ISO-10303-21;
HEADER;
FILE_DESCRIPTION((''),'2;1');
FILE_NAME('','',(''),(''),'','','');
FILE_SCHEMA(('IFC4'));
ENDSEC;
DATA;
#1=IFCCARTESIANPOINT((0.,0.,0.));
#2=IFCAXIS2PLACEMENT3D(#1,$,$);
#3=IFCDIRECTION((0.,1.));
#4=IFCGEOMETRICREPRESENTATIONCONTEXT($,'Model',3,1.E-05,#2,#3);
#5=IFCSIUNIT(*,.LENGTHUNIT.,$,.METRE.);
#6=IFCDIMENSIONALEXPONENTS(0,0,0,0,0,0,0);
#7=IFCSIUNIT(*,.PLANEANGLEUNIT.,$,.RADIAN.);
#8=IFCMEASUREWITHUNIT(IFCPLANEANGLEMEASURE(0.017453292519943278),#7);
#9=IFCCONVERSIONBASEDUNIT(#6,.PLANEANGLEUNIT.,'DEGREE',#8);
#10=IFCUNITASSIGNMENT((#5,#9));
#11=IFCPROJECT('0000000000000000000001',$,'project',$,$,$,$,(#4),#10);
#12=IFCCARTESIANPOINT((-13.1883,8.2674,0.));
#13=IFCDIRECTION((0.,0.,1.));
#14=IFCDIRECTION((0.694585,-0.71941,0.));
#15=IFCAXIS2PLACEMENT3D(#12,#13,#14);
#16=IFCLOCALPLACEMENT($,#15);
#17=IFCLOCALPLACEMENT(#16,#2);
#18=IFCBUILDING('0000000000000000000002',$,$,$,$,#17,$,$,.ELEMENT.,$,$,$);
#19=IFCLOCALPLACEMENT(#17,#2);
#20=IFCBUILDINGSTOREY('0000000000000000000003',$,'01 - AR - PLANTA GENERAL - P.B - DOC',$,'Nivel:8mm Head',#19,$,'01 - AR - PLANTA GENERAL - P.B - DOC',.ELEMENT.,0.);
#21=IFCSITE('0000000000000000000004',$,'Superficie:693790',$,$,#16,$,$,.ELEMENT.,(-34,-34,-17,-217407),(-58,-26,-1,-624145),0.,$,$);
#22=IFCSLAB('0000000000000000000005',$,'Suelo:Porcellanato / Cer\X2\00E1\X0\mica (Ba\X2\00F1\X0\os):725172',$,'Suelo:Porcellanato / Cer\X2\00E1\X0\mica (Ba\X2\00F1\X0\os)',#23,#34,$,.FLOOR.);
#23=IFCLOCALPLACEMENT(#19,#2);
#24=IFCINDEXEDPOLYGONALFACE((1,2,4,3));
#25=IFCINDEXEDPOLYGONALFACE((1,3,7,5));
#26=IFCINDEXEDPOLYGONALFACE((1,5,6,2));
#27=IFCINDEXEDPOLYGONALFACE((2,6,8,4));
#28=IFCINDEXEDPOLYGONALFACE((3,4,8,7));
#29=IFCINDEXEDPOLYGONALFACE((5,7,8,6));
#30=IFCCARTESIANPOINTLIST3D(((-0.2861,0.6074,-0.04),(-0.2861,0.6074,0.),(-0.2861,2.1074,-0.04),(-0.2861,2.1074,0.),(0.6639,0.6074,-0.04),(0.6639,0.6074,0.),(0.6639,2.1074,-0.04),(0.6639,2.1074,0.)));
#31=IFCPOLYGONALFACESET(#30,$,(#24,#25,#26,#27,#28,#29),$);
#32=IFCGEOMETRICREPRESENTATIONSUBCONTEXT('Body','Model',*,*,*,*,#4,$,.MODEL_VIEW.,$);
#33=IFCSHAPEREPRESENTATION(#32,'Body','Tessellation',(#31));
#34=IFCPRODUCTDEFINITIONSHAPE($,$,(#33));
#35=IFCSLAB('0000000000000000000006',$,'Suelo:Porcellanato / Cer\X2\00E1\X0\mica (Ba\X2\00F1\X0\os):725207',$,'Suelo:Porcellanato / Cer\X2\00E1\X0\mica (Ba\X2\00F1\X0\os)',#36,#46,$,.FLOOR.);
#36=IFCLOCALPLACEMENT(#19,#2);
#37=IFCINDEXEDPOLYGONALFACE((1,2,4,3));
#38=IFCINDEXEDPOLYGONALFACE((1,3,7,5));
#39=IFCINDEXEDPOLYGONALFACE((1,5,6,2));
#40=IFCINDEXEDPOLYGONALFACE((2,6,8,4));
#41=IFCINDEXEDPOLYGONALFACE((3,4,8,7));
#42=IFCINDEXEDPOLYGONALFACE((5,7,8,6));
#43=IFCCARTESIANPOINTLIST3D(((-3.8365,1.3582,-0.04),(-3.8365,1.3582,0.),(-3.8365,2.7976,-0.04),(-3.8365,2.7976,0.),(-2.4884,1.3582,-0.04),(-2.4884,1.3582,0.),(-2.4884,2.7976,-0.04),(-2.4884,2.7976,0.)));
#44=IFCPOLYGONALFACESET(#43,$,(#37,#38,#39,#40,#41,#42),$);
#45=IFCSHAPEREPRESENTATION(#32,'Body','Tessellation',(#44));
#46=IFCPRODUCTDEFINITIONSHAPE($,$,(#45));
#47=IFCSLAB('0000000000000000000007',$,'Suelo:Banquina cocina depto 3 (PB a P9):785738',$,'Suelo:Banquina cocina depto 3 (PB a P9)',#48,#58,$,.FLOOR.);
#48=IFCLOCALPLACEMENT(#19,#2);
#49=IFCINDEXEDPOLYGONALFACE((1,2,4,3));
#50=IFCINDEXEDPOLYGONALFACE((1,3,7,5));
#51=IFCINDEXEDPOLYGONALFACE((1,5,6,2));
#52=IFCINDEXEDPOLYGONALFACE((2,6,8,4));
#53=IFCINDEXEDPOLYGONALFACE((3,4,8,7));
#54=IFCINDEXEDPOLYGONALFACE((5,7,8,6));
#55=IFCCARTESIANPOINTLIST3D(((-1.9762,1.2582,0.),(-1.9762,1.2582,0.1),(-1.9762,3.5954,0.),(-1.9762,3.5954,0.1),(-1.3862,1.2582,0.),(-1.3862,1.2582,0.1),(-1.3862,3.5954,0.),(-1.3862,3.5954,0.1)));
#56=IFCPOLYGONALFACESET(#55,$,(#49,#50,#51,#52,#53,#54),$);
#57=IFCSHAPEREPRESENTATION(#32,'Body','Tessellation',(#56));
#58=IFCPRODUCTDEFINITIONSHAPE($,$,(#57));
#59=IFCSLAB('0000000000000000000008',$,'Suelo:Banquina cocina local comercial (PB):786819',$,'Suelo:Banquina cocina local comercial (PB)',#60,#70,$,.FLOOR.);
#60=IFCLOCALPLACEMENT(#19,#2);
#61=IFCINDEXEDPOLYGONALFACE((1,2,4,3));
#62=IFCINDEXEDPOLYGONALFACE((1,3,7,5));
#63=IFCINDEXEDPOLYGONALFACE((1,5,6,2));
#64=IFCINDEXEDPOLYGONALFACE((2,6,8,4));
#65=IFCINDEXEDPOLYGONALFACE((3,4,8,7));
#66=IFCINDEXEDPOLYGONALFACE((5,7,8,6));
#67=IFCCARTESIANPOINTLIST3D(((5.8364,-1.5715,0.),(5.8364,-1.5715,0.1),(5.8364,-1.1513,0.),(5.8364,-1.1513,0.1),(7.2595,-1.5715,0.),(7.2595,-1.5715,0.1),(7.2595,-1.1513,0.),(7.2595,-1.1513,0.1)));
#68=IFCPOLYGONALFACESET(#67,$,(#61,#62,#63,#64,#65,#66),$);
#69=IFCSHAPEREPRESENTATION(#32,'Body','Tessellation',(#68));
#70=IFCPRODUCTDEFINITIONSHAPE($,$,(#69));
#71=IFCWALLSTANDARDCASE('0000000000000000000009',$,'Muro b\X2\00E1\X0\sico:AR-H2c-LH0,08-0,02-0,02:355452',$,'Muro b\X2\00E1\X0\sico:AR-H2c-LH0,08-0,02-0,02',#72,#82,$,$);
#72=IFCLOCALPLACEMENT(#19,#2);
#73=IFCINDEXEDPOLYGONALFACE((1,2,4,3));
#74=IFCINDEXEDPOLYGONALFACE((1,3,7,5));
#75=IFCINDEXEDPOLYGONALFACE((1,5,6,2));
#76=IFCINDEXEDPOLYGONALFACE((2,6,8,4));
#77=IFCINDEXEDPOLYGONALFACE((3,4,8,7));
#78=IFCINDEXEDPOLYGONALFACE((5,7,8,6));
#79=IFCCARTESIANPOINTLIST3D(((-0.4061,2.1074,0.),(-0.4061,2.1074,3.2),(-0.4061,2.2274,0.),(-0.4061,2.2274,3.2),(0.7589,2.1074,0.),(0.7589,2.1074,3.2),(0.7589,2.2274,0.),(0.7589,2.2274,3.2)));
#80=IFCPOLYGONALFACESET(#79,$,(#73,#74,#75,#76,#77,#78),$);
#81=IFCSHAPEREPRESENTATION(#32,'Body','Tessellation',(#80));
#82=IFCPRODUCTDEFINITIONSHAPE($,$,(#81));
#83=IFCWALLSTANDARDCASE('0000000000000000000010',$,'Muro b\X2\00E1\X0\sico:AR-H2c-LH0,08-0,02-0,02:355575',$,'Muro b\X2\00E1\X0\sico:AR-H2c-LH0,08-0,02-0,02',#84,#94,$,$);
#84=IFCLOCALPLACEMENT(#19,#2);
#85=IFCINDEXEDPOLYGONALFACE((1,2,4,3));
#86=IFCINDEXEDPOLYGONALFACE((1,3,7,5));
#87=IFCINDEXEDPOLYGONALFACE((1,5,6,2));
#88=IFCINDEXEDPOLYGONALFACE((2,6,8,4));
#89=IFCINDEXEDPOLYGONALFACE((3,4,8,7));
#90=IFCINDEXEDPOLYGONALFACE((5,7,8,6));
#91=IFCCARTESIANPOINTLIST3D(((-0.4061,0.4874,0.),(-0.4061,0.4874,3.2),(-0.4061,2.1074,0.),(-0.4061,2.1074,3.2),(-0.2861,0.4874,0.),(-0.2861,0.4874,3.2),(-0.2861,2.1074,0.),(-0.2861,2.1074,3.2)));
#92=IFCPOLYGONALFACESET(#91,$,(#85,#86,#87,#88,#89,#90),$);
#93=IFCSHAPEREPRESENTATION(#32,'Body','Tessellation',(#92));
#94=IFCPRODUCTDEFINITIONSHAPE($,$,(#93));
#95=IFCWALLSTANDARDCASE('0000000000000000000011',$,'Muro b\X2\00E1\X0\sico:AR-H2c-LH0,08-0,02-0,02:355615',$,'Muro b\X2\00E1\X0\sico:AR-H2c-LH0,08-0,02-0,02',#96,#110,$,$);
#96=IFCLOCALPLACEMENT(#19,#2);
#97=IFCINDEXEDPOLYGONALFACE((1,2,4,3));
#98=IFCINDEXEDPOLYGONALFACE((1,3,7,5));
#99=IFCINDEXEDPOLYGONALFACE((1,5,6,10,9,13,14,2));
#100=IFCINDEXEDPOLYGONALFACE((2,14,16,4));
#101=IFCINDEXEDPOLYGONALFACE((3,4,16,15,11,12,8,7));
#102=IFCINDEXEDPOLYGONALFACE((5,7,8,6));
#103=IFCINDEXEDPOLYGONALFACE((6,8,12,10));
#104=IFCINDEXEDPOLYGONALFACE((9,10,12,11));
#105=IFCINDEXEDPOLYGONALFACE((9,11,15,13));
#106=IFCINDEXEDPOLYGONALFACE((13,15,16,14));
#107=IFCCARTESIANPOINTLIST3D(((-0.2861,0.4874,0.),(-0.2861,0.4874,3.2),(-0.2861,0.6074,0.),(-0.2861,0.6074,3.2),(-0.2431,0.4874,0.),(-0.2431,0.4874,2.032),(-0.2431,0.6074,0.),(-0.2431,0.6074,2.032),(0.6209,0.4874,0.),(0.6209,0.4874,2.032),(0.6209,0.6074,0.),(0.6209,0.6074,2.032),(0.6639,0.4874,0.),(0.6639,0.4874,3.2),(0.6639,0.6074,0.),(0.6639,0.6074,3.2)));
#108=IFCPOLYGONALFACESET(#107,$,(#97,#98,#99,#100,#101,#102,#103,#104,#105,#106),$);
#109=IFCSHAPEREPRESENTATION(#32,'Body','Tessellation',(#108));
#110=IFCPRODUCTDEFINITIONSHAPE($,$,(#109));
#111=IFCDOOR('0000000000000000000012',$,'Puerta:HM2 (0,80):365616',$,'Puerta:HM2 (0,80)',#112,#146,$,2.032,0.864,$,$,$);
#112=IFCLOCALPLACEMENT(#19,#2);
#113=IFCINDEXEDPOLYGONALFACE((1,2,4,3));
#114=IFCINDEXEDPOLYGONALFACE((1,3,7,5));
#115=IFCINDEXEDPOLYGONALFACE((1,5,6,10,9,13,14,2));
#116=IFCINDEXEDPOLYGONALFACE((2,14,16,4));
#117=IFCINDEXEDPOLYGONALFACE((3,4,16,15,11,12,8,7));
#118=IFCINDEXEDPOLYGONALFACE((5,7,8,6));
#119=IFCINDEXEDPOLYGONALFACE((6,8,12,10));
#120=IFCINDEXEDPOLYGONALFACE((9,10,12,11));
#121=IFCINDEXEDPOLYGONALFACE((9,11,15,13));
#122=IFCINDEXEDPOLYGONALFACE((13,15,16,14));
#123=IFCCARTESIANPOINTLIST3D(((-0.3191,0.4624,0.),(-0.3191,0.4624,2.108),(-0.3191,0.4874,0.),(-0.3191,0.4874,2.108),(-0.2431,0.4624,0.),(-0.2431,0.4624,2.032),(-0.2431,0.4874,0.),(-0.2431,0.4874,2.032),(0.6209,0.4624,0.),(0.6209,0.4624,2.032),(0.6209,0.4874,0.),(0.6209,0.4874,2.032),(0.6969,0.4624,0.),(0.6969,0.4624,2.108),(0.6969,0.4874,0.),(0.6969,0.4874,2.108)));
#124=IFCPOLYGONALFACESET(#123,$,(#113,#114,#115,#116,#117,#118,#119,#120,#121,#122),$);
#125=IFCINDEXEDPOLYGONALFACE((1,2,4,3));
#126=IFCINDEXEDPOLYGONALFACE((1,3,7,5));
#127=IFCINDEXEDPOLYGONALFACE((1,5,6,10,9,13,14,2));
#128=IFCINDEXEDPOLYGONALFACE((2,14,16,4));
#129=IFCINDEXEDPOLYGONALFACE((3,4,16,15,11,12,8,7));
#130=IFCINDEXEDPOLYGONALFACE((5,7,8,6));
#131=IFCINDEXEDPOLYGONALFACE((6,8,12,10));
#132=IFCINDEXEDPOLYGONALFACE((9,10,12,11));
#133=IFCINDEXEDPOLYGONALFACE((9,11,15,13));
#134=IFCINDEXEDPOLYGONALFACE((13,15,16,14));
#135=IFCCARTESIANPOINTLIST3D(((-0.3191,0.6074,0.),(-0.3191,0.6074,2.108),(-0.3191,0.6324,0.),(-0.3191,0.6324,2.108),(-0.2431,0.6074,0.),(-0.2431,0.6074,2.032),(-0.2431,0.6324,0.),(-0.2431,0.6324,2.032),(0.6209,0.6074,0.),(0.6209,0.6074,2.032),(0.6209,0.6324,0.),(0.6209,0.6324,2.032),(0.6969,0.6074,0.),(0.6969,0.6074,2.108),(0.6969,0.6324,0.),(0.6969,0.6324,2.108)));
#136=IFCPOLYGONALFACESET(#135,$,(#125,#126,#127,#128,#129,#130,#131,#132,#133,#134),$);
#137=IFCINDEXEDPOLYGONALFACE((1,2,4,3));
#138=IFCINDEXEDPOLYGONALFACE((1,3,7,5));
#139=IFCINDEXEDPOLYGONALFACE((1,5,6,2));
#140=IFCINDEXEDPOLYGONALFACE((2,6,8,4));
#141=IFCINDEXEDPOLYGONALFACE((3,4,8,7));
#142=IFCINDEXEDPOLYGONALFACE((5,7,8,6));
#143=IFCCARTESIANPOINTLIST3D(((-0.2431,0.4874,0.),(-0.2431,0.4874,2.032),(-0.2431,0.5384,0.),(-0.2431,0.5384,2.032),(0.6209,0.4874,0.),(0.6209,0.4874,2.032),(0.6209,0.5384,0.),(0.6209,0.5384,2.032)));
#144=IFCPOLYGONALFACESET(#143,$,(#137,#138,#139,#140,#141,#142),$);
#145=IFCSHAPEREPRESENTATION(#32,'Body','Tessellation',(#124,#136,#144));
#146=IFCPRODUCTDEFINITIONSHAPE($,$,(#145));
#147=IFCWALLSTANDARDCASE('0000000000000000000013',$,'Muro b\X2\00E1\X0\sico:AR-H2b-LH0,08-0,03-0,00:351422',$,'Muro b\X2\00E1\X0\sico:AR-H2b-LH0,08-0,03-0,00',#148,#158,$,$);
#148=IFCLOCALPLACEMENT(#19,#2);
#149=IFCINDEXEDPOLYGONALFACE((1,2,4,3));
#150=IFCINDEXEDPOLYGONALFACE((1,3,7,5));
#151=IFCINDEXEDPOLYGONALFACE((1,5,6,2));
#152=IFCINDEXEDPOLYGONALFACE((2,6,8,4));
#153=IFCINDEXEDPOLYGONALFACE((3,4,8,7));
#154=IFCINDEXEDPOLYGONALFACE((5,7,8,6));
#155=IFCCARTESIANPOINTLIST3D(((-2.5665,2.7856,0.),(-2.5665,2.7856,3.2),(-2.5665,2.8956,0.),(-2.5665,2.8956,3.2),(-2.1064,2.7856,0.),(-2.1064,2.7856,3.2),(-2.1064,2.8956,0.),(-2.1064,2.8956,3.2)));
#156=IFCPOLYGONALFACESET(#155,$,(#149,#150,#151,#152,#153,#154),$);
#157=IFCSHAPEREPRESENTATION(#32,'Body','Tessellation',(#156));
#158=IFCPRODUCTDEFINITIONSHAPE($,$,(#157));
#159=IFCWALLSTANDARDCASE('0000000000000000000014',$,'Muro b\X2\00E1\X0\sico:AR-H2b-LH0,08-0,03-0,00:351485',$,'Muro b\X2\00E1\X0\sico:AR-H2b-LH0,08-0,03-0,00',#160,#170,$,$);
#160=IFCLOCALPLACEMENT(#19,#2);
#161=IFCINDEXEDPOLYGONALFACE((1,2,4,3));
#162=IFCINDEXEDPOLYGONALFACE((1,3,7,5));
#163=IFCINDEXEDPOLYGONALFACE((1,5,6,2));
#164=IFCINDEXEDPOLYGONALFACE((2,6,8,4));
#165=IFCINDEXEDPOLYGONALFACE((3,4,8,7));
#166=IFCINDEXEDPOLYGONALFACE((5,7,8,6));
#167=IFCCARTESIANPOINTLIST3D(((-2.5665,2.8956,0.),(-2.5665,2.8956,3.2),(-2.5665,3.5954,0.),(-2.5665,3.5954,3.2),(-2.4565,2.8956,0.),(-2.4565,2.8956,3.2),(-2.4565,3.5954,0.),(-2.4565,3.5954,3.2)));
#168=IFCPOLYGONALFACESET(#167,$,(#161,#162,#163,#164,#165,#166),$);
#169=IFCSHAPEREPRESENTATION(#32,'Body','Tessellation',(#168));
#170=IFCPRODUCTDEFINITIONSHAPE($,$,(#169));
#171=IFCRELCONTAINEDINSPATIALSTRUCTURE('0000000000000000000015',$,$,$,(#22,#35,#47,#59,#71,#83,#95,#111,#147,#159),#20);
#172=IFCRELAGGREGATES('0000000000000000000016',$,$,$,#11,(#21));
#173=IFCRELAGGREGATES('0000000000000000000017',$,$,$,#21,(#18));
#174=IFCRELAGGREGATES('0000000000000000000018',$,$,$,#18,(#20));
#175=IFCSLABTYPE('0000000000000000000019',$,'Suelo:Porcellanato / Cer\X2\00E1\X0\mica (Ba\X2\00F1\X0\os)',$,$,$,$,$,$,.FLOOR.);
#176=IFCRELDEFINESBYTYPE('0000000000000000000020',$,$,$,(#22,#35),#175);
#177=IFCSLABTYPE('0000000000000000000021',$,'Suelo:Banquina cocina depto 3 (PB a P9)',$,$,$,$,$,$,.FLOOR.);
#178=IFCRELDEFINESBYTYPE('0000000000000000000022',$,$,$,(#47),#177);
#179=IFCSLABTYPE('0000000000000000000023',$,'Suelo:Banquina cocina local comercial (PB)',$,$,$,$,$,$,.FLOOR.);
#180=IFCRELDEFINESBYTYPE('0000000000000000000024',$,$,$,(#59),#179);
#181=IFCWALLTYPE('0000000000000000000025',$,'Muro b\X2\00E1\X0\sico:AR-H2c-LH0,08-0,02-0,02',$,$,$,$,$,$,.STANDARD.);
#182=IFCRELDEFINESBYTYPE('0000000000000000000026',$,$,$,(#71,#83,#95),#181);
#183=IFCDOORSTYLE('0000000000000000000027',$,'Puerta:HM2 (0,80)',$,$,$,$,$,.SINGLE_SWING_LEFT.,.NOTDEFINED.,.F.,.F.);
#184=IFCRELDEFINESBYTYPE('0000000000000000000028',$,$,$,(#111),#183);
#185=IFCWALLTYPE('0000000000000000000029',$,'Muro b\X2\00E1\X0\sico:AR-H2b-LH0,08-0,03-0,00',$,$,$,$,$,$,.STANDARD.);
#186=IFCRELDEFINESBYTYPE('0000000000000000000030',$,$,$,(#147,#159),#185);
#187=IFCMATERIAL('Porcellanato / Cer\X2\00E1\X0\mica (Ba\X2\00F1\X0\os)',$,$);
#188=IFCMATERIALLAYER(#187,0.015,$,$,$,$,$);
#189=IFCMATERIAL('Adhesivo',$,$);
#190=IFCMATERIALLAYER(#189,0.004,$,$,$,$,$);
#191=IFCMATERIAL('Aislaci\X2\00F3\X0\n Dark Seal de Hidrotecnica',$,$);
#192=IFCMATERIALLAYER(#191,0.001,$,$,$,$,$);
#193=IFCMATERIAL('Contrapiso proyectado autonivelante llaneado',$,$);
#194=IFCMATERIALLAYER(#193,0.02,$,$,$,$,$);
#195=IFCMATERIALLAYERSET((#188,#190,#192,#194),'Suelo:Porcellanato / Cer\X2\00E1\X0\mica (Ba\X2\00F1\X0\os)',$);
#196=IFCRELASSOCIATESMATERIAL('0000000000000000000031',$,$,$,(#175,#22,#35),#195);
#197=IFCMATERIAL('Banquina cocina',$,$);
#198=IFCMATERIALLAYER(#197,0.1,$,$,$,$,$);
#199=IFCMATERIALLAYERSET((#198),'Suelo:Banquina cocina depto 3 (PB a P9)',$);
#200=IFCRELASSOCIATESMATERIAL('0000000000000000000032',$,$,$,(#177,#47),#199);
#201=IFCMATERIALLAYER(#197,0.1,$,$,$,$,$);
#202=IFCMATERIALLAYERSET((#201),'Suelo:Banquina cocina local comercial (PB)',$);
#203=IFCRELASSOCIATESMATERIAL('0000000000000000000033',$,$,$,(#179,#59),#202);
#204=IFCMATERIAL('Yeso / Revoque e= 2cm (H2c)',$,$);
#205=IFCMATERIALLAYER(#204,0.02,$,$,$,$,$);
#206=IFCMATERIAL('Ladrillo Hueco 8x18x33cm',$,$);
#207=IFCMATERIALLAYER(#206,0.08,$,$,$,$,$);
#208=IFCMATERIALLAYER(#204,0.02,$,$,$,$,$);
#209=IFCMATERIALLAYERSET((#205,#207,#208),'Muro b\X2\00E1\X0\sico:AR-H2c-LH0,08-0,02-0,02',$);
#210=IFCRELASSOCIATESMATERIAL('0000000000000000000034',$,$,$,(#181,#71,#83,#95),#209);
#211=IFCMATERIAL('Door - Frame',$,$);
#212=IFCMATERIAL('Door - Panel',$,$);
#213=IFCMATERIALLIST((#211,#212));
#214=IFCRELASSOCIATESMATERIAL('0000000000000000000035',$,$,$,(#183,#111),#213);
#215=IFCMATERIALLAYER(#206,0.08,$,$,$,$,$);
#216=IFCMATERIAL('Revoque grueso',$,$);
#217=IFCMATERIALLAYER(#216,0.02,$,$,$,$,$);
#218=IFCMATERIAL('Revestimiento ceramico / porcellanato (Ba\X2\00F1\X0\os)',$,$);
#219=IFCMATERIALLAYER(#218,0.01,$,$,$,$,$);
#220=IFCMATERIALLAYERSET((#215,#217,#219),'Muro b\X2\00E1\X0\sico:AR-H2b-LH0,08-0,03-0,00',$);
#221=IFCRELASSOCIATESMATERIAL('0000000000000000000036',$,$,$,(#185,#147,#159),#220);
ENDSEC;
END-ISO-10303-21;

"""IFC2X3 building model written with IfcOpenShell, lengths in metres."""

from ifc_helpers import new_model, entity, si_unit, converted_unit, direction, frame, frame_2d, origin, origin_2d_with_axis, place, context, subcontext, project, spatial, polyline, rectangle, outline, extrude, source, transform, mapped, material, material_list, layer, layer_set, layer_usage, type_object, type_shapes, element, fill, save


model = new_model("IFC2X3")

# Units and contexts
model_context = context("Model", 3, precision=1e-05, world=origin(), true_north=direction((0.0, 1.0)))
body_context = subcontext(model_context, "Body", "Model", "MODEL_VIEW")
ifc_project = project(units=[si_unit("LENGTHUNIT", "METRE"), converted_unit("PLANEANGLEUNIT", "DEGREE", entity("IfcPlaneAngleMeasure", 0.017453292519943278), si_unit("PLANEANGLEUNIT", "RADIAN"), dimensions=[0, 0, 0, 0, 0, 0, 0])], contexts=[model_context])

# Site, building, storey
site_placement = place(None, frame((-13.1883, 8.2674, 0.0), z_axis=(0.0, 0.0, 1.0), x_axis=(0.694585, -0.71941, 0.0)))
site = spatial("IfcSite", under=ifc_project, at=site_placement, Name="Superficie:693790", CompositionType="ELEMENT", RefLatitude=(-34, -34, -17, -217407), RefLongitude=(-58, -26, -1, -624145), RefElevation=0.0)
building_placement = place(site_placement, origin())
building = spatial("IfcBuilding", under=site, at=building_placement, CompositionType="ELEMENT")
storey_placement = place(building_placement, origin())
storey = spatial("IfcBuildingStorey", under=building, at=storey_placement, Name="01 - AR - PLANTA GENERAL - P.B - DOC", ObjectType="Nivel:8mm Head", LongName="01 - AR - PLANTA GENERAL - P.B - DOC", CompositionType="ELEMENT", Elevation=0.0)

# Slabs
ifc_material_1 = material(Name="Adhesivo")
ifc_material_2 = material(Name="Contrapiso proyectado autonivelante llaneado")
ifc_material_3 = material(Name="Porcellanato / Cerámica (Baños)")
ifc_layer_1 = layer(ifc_material_3, 0.015)
ifc_layer_2 = layer(ifc_material_1, 0.004)
ifc_material_4 = material(Name="Aislación Dark Seal de Hidrotecnica")
ifc_layer_3 = layer(ifc_material_4, 0.001)
ifc_layer_4 = layer(ifc_material_2, 0.02)
ifc_layer_set_1 = layer_set([ifc_layer_1, ifc_layer_2, ifc_layer_3, ifc_layer_4], Name="Suelo:Porcellanato / Cerámica (Baños)")
ifc_layer_usage_1 = layer_usage(ifc_layer_set_1, "AXIS3", "POSITIVE", 0.0)
slab_type_1 = type_object("IfcSlabType", Name="Suelo:Porcellanato / Cerámica (Baños)", PredefinedType="FLOOR", material=ifc_layer_set_1)
slab_1_placement = place(storey_placement, origin())
element("IfcSlab", 1, at=slab_1_placement, inside=storey, type_object=slab_type_1, material=ifc_layer_usage_1, Name="Suelo:Porcellanato / Cerámica (Baños):725172", ObjectType="Suelo:Porcellanato / Cerámica (Baños)", PredefinedType="FLOOR", context=body_context, shape_type="SweptSolid", body=[
    extrude(rectangle(XDim=1.5, YDim=0.95, at=frame_2d((0.0, 0.0), x_axis=(1.0, 0.0))), frame((0.1889, 1.3574, 0.0), z_axis=(0.0, 0.0, -1.0), x_axis=(0.0, 1.0, 0.0)), (0.0, 0.0, 1.0), 0.04),
])
ifc_layer_usage_2 = layer_usage(ifc_layer_set_1, "AXIS3", "POSITIVE", 0.0)
slab_2_placement = place(storey_placement, origin())
element("IfcSlab", 2, at=slab_2_placement, inside=storey, type_object=slab_type_1, material=ifc_layer_usage_2, Name="Suelo:Porcellanato / Cerámica (Baños):725207", ObjectType="Suelo:Porcellanato / Cerámica (Baños)", PredefinedType="FLOOR", context=body_context, shape_type="SweptSolid", body=[
    extrude(rectangle(XDim=1.4395, YDim=1.348, at=frame_2d((0.0, 0.0), x_axis=(1.0, 0.0))), frame((-3.1625, 2.0779, 0.0), z_axis=(0.0, 0.0, -1.0), x_axis=(0.0, 1.0, 0.0)), (0.0, 0.0, 1.0), 0.04),
])
ifc_material_5 = material(Name="Banquina cocina")
ifc_layer_5 = layer(ifc_material_5, 0.1)
ifc_layer_set_2 = layer_set([ifc_layer_5], Name="Suelo:Banquina cocina depto 3 (PB a P9)")
ifc_layer_usage_3 = layer_usage(ifc_layer_set_2, "AXIS3", "POSITIVE", 0.0)
slab_type_2 = type_object("IfcSlabType", Name="Suelo:Banquina cocina depto 3 (PB a P9)", PredefinedType="FLOOR", material=ifc_layer_set_2)
slab_3_placement = place(storey_placement, origin())
element("IfcSlab", 3, at=slab_3_placement, inside=storey, type_object=slab_type_2, material=ifc_layer_usage_3, Name="Suelo:Banquina cocina depto 3 (PB a P9):785738", ObjectType="Suelo:Banquina cocina depto 3 (PB a P9)", PredefinedType="FLOOR", context=body_context, shape_type="SweptSolid", body=[
    extrude(rectangle(XDim=2.3373, YDim=0.59, at=frame_2d((0.0, 0.0), x_axis=(1.0, 0.0))), frame((-1.6812, 2.4268, 0.1), z_axis=(0.0, 0.0, -1.0), x_axis=(0.0, 1.0, 0.0)), (0.0, 0.0, 1.0), 0.1),
])
ifc_layer_6 = layer(ifc_material_5, 0.1)
ifc_layer_set_3 = layer_set([ifc_layer_6], Name="Suelo:Banquina cocina local comercial (PB)")
ifc_layer_usage_4 = layer_usage(ifc_layer_set_3, "AXIS3", "POSITIVE", 0.0)
slab_type_3 = type_object("IfcSlabType", Name="Suelo:Banquina cocina local comercial (PB)", PredefinedType="FLOOR", material=ifc_layer_set_3)
slab_4_placement = place(storey_placement, origin())
element("IfcSlab", 4, at=slab_4_placement, inside=storey, type_object=slab_type_3, material=ifc_layer_usage_4, Name="Suelo:Banquina cocina local comercial (PB):786819", ObjectType="Suelo:Banquina cocina local comercial (PB)", PredefinedType="FLOOR", context=body_context, shape_type="SweptSolid", body=[
    extrude(rectangle(XDim=0.4202, YDim=1.4231, at=frame_2d((0.0, 0.0), x_axis=(1.0, 0.0))), frame((6.548, -1.3614, 0.1), z_axis=(0.0, 0.0, -1.0), x_axis=(0.0, 1.0, 0.0)), (0.0, 0.0, 1.0), 0.1),
])

# Walls
ifc_material_6 = material(Name="Yeso / Revoque e= 2cm (H2c)")
ifc_layer_7 = layer(ifc_material_6, 0.02)
ifc_material_7 = material(Name="Ladrillo Hueco 8x18x33cm")
ifc_layer_8 = layer(ifc_material_7, 0.08)
ifc_layer_9 = layer(ifc_material_6, 0.02)
ifc_layer_set_4 = layer_set([ifc_layer_7, ifc_layer_8, ifc_layer_9], Name="Muro básico:AR-H2c-LH0,08-0,02-0,02")
ifc_layer_usage_5 = layer_usage(ifc_layer_set_4, "AXIS2", "NEGATIVE", 0.06)
wall_type_1 = type_object("IfcWallType", Name="Muro básico:AR-H2c-LH0,08-0,02-0,02", PredefinedType="STANDARD", material=ifc_layer_set_4)
wall_1_placement = place(storey_placement, frame((-0.4061, 2.1674, 0.0)))
element("IfcWallStandardCase", 5, at=wall_1_placement, inside=storey, type_object=wall_type_1, material=ifc_layer_usage_5, Name="Muro básico:AR-H2c-LH0,08-0,02-0,02:355452", ObjectType="Muro básico:AR-H2c-LH0,08-0,02-0,02", context=body_context, shape_type="SweptSolid", body=[
    extrude(rectangle(XDim=1.165, YDim=0.12, at=frame_2d((0.5825, 0.0), x_axis=(-1.0, 0.0))), origin(), (0.0, 0.0, 1.0), 3.2),
])
ifc_layer_usage_6 = layer_usage(ifc_layer_set_4, "AXIS2", "POSITIVE", -0.06)
wall_2_placement = place(storey_placement, frame((-0.3461, 2.1074, 0.0), z_axis=(0.0, 0.0, 1.0), x_axis=(0.0, -1.0, 0.0)))
element("IfcWallStandardCase", 6, at=wall_2_placement, inside=storey, type_object=wall_type_1, material=ifc_layer_usage_6, Name="Muro básico:AR-H2c-LH0,08-0,02-0,02:355575", ObjectType="Muro básico:AR-H2c-LH0,08-0,02-0,02", context=body_context, shape_type="SweptSolid", body=[
    extrude(rectangle(XDim=1.62, YDim=0.12, at=frame_2d((0.81, 0.0), x_axis=(-1.0, 0.0))), origin(), (0.0, 0.0, 1.0), 3.2),
])

# Wall, opening, door
ifc_layer_usage_7 = layer_usage(ifc_layer_set_4, "AXIS2", "POSITIVE", -0.06)
wall_3_placement = place(storey_placement, frame((-0.2861, 0.5474, 0.0)))
wall_3 = element("IfcWallStandardCase", 7, at=wall_3_placement, inside=storey, type_object=wall_type_1, material=ifc_layer_usage_7, Name="Muro básico:AR-H2c-LH0,08-0,02-0,02:355615", ObjectType="Muro básico:AR-H2c-LH0,08-0,02-0,02", context=body_context, shape_type="SweptSolid", body=[
    extrude(rectangle(XDim=0.95, YDim=0.12, at=frame_2d((0.475, 0.0), x_axis=(1.0, 0.0))), origin(), (0.0, 0.0, 1.0), 3.2),
])
opening_placement = place(wall_3_placement, frame((0.907, 0.06, 0.0)))
opening = element("IfcOpeningElement", 8, at=opening_placement, cuts=wall_3, ObjectType="Opening", context=body_context, shape_type="SweptSolid", body=[
    extrude(rectangle(XDim=0.864, YDim=2.032, at=frame_2d((1.016, 0.432), x_axis=(0.0, -1.0))), frame((0.0, 0.0, 0.0), z_axis=(0.0, -1.0, 0.0), x_axis=(0.0, 0.0, 1.0)), (0.0, 0.0, 1.0), 0.12),
])
ifc_material_8 = material(Name="Door - Frame")
ifc_material_9 = material(Name="Door - Panel")
ifc_material_list_1 = material_list([ifc_material_8, ifc_material_9])
door_style = type_object("IfcDoorStyle", Name="Puerta:HM2 (0,80)", ConstructionType="NOTDEFINED", OperationType="SINGLE_SWING_LEFT", ParameterTakesPrecedence=False, Sizeable=False, material=ifc_material_list_1)
shared_shape_1 = source(origin(), body_context, "Body", "SweptSolid", [
    extrude(outline(polyline([(-0.508, -1.073), (0.508, -1.073), (0.508, 1.035), (0.432, 1.035), (0.432, -0.997), (-0.432, -0.997), (-0.432, 1.035), (-0.508, 1.035), (-0.508, -1.073)])), frame((0.432, 0.145, 1.035), z_axis=(0.0, -1.0, 0.0), x_axis=(-1.0, 0.0, 0.0)), (0.0, 0.0, 1.0), 0.025),
    extrude(outline(polyline([(-1.073, -0.508), (1.035, -0.508), (1.035, -0.432), (-0.997, -0.432), (-0.997, 0.432), (1.035, 0.432), (1.035, 0.508), (-1.073, 0.508), (-1.073, -0.508)])), frame((0.432, 0.0, 1.035), z_axis=(0.0, -1.0, 0.0), x_axis=(0.0, 0.0, -1.0)), (0.0, 0.0, 1.0), 0.025),
    extrude(rectangle(XDim=0.864, YDim=0.051, at=origin_2d_with_axis()), frame((0.432, 0.0945, 0.0)), (0.0, 0.0, 1.0), 2.032),
])
type_shapes(door_style, [shared_shape_1])
door_placement = place(opening_placement, frame((0.0, 0.0, 0.0), z_axis=(0.0, 0.0, 1.0), x_axis=(-1.0, 0.0, 0.0)))
door = element("IfcDoor", 9, at=door_placement, inside=storey, type_object=door_style, material=ifc_material_list_1, Name="Puerta:HM2 (0,80):365616", ObjectType="Puerta:HM2 (0,80)", OverallHeight=2.032, OverallWidth=0.864, context=body_context, shape_type="MappedRepresentation", body=[
    mapped(shared_shape_1, transform((0.0, 0.0, 0.0), scale=1.0)),
])
fill(opening, door)

# Walls
ifc_layer_10 = layer(ifc_material_7, 0.08)
ifc_material_10 = material(Name="Revoque grueso")
ifc_layer_11 = layer(ifc_material_10, 0.02)
ifc_material_11 = material(Name="Revestimiento ceramico / porcellanato (Baños)")
ifc_layer_12 = layer(ifc_material_11, 0.01)
ifc_layer_set_5 = layer_set([ifc_layer_10, ifc_layer_11, ifc_layer_12], Name="Muro básico:AR-H2b-LH0,08-0,03-0,00")
ifc_layer_usage_8 = layer_usage(ifc_layer_set_5, "AXIS2", "POSITIVE", -0.055)
wall_type_2 = type_object("IfcWallType", Name="Muro básico:AR-H2b-LH0,08-0,03-0,00", PredefinedType="STANDARD", material=ifc_layer_set_5)
wall_4_placement = place(storey_placement, frame((-2.1064, 2.8406, 0.0), z_axis=(0.0, 0.0, 1.0), x_axis=(-1.0, 0.0, 0.0)))
element("IfcWallStandardCase", 10, at=wall_4_placement, inside=storey, type_object=wall_type_2, material=ifc_layer_usage_8, Name="Muro básico:AR-H2b-LH0,08-0,03-0,00:351422", ObjectType="Muro básico:AR-H2b-LH0,08-0,03-0,00", context=body_context, shape_type="SweptSolid", body=[
    extrude(rectangle(XDim=0.46, YDim=0.11, at=frame_2d((0.23, 0.0), x_axis=(-1.0, 0.0))), origin(), (0.0, 0.0, 1.0), 3.2),
])
ifc_layer_usage_9 = layer_usage(ifc_layer_set_5, "AXIS2", "POSITIVE", -0.055)
wall_5_placement = place(storey_placement, frame((-2.5115, 2.8956, 0.0), z_axis=(0.0, 0.0, 1.0), x_axis=(0.0, 1.0, 0.0)))
element("IfcWallStandardCase", 11, at=wall_5_placement, inside=storey, type_object=wall_type_2, material=ifc_layer_usage_9, Name="Muro básico:AR-H2b-LH0,08-0,03-0,00:351485", ObjectType="Muro básico:AR-H2b-LH0,08-0,03-0,00", context=body_context, shape_type="SweptSolid", body=[
    extrude(rectangle(XDim=0.6998, YDim=0.11, at=frame_2d((0.3499, 0.0), x_axis=(-1.0, 0.0))), origin(), (0.0, 0.0, 1.0), 3.2),
])

save(model, "model.ifc")
